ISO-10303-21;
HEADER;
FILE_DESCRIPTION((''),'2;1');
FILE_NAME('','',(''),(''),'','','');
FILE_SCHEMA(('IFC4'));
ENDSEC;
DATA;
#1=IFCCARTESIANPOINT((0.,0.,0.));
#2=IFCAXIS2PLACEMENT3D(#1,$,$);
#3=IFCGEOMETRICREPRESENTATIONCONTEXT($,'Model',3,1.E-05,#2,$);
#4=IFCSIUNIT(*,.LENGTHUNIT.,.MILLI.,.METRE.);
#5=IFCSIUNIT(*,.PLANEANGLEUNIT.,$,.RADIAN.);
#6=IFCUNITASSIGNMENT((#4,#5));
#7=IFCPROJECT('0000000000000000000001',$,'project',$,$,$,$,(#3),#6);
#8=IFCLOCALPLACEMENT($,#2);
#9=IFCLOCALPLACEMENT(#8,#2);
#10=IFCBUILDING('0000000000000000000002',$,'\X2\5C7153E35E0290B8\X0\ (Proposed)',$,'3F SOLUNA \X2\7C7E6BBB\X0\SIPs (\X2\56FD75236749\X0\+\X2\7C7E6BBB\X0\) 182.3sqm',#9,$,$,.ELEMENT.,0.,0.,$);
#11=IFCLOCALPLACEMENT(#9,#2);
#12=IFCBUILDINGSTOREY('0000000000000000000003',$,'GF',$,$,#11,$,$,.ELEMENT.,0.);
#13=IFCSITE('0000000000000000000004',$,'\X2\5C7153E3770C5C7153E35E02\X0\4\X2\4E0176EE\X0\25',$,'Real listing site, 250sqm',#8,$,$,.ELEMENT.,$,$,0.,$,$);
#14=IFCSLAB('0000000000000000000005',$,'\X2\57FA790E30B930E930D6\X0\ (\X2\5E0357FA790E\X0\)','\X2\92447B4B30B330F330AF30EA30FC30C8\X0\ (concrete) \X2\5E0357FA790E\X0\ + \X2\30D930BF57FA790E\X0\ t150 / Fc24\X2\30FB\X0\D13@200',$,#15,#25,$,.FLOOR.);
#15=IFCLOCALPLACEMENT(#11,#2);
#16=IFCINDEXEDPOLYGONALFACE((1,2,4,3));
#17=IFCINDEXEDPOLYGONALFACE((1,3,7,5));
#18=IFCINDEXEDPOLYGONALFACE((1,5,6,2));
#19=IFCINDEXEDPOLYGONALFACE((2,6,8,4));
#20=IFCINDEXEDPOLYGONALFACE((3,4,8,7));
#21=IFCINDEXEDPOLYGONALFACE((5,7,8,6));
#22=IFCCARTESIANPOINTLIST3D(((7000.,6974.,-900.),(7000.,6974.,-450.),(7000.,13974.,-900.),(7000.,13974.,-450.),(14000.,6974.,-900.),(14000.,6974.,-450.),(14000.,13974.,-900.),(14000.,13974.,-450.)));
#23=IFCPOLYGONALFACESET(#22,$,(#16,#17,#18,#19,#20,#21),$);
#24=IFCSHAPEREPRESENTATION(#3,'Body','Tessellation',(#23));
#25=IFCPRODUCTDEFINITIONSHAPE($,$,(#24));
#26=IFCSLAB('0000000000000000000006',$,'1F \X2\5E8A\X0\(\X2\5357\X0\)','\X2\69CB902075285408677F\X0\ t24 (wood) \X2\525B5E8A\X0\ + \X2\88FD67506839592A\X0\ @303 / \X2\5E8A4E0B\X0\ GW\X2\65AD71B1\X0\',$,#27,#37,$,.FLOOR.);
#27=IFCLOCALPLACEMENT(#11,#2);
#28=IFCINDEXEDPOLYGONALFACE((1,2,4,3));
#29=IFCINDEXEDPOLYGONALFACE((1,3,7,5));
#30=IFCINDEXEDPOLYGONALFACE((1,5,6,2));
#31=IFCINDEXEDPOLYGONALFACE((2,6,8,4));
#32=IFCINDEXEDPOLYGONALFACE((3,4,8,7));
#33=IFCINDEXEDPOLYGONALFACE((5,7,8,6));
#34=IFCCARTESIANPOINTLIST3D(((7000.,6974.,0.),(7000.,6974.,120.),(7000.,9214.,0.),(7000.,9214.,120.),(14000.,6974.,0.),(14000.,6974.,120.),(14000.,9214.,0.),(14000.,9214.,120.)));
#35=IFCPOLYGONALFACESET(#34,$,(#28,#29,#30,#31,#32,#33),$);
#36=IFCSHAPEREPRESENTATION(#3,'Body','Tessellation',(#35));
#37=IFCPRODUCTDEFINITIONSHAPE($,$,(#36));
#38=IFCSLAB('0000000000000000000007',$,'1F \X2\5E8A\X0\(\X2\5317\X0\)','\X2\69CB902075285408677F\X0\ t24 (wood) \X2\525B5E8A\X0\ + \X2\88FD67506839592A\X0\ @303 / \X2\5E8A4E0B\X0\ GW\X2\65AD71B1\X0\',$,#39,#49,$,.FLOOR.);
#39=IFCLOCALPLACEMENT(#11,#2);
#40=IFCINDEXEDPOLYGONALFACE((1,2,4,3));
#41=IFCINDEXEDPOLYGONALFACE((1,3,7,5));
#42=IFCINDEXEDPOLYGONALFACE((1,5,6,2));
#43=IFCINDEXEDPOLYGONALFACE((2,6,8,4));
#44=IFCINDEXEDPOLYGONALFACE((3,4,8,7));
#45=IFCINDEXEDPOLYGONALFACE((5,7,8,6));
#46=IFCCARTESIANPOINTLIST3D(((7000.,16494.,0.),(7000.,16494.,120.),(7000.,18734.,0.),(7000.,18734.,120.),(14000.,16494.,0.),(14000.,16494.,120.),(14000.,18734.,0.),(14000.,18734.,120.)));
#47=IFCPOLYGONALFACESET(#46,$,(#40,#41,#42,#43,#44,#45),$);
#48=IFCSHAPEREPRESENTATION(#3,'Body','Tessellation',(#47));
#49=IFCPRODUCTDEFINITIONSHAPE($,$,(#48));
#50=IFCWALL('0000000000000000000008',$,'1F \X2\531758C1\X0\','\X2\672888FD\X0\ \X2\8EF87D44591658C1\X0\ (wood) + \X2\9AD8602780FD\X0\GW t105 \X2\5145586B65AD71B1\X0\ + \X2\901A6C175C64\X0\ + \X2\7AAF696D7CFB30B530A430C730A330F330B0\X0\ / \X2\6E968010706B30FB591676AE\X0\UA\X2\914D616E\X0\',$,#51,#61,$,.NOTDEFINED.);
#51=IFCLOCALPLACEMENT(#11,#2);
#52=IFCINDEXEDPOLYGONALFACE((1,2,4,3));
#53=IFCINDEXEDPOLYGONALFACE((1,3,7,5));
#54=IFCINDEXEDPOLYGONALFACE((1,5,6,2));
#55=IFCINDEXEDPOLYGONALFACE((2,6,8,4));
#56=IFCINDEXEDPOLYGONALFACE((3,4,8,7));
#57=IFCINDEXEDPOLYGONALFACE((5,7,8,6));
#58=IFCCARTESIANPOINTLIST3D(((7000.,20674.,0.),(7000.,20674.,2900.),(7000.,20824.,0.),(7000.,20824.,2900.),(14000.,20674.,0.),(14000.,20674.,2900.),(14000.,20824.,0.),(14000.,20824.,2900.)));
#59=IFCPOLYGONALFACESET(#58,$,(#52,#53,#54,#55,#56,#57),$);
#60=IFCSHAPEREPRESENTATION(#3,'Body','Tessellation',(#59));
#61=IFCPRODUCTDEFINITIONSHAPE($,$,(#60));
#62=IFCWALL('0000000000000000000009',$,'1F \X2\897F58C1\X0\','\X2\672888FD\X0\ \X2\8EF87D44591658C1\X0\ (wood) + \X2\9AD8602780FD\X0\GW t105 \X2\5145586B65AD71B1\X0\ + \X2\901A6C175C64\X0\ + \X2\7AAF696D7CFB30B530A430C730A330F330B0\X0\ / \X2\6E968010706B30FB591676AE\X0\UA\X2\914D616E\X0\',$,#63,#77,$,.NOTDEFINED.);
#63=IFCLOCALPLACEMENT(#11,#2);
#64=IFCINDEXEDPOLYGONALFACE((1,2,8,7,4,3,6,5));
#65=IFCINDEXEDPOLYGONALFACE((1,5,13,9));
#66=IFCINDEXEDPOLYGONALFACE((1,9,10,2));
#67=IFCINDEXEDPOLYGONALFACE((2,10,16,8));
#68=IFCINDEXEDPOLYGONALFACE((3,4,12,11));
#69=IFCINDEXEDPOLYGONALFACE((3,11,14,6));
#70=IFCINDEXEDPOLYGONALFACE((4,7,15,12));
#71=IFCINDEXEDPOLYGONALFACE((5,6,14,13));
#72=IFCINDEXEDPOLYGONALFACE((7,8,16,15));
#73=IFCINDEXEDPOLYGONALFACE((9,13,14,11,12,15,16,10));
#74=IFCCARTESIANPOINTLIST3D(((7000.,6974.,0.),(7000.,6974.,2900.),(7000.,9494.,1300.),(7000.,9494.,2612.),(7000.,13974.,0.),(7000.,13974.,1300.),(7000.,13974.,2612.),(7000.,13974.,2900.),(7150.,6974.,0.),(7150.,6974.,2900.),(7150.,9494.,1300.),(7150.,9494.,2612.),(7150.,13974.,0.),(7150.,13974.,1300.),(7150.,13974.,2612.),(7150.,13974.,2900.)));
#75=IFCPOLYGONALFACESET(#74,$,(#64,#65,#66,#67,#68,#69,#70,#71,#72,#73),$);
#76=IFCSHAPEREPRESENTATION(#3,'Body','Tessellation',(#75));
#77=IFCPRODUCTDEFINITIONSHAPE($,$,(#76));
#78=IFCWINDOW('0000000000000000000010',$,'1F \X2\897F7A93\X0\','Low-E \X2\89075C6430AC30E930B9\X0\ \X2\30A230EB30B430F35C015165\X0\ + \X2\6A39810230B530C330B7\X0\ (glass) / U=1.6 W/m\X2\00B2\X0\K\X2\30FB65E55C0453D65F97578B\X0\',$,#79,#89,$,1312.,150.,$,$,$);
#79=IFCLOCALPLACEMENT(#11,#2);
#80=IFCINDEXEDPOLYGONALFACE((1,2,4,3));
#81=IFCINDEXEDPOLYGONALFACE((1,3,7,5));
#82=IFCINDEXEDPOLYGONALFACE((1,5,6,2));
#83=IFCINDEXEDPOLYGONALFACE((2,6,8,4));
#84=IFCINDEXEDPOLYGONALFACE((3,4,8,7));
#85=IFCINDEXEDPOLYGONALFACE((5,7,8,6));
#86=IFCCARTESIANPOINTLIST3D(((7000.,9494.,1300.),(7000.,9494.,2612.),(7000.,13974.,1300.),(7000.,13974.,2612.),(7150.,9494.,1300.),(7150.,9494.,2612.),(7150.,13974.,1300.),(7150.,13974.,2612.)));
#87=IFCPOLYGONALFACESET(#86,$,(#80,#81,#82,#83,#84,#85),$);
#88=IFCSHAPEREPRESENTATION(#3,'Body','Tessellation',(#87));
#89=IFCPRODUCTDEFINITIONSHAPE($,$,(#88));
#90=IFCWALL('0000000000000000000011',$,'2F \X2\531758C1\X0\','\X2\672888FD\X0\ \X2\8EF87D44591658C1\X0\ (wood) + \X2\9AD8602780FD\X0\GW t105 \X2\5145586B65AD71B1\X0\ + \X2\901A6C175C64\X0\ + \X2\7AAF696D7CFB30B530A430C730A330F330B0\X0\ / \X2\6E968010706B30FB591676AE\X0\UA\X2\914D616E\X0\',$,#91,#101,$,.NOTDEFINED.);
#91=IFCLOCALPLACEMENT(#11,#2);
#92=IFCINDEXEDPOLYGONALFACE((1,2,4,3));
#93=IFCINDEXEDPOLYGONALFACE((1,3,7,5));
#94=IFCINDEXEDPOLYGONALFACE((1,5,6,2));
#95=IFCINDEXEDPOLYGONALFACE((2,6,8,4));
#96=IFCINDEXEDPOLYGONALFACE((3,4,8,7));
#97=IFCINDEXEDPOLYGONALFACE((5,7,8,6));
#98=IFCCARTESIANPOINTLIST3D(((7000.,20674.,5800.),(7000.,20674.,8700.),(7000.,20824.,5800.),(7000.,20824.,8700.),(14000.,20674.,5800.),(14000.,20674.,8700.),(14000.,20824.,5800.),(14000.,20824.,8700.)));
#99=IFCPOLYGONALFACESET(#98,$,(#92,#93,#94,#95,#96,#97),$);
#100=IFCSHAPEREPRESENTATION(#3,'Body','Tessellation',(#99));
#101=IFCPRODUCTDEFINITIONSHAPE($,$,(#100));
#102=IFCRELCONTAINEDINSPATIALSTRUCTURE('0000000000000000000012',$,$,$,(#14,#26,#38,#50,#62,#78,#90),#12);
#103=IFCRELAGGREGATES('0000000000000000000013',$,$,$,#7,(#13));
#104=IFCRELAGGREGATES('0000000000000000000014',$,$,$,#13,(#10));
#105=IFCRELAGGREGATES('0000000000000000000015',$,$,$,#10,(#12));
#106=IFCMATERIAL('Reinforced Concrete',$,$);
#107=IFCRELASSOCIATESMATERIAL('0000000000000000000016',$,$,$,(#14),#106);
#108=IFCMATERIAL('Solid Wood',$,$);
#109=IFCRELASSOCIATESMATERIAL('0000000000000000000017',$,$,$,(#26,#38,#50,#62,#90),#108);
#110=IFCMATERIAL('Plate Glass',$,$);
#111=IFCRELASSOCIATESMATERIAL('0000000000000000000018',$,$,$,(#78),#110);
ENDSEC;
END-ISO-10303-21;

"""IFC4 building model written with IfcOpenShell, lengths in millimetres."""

from ifc_helpers import new_model, si_unit, frame, frame_2d, origin, place, context, project, spatial, rectangle, extrude, material, element, fill, save


model = new_model("IFC4")

# Units and contexts
model_context = context("Model", 3, precision=1e-05, world=origin())
ifc_project = project(units=[si_unit("LENGTHUNIT", "METRE", prefix="MILLI"), si_unit("PLANEANGLEUNIT", "RADIAN")], contexts=[model_context])

# Site, building, storey
site_placement = place(None, origin())
site = spatial("IfcSite", under=ifc_project, at=site_placement, Name="山口県山口市4丁目25", ObjectType="Real listing site, 250sqm", CompositionType="ELEMENT", RefElevation=0.0)
building_placement = place(site_placement, origin())
building = spatial("IfcBuilding", under=site, at=building_placement, Name="山口市邸 (Proposed)", ObjectType="3F SOLUNA 籾殻SIPs (国産杉+籾殻) 182.3sqm", CompositionType="ELEMENT", ElevationOfRefHeight=0.0, ElevationOfTerrain=0.0)
storey_placement = place(building_placement, origin())
storey = spatial("IfcBuildingStorey", under=building, at=storey_placement, Name="GF", CompositionType="ELEMENT", Elevation=0.0)

# Slabs
ifc_material_1 = material(Name="Reinforced Concrete")
slab_1_placement = place(storey_placement, frame((3500.0, 3487.0, -450.0)))
element("IfcSlab", 1, at=slab_1_placement, inside=storey, material=ifc_material_1, Name="基礎スラブ (布基礎)", Description="鉄筋コンクリート (concrete) 布基礎 + ベタ基礎 t150 / Fc24・D13@200", PredefinedType="FLOOR", context=model_context, shape_type="SweptSolid", body=[
    extrude(rectangle(XDim=7000.0, YDim=7000.0, at=frame_2d((3500.0, 3500.0))), frame((3500.0, 3487.0, -450.0)), (0.0, 0.0, 1.0), 450.0),
])
ifc_material_2 = material(Name="Solid Wood")
slab_2_placement = place(storey_placement, frame((3500.0, 3487.0, 0.0)))
element("IfcSlab", 2, at=slab_2_placement, inside=storey, material=ifc_material_2, Name="1F 床(南)", Description="構造用合板 t24 (wood) 剛床 + 製材根太 @303 / 床下 GW断熱", PredefinedType="FLOOR", context=model_context, shape_type="SweptSolid", body=[
    extrude(rectangle(XDim=7000.0, YDim=2240.0, at=frame_2d((3500.0, 1120.0))), frame((3500.0, 3487.0, 0.0)), (0.0, 0.0, 1.0), 120.0),
])
slab_3_placement = place(storey_placement, frame((3500.0, 8247.0, 0.0)))
element("IfcSlab", 3, at=slab_3_placement, inside=storey, material=ifc_material_2, Name="1F 床(北)", Description="構造用合板 t24 (wood) 剛床 + 製材根太 @303 / 床下 GW断熱", PredefinedType="FLOOR", context=model_context, shape_type="SweptSolid", body=[
    extrude(rectangle(XDim=7000.0, YDim=2240.0, at=frame_2d((3500.0, 1120.0))), frame((3500.0, 8247.0, 0.0)), (0.0, 0.0, 1.0), 120.0),
])

# Shared definitions
ifc_material_3 = material(Name="Plate Glass")

# Wall
wall_1_placement = place(storey_placement, frame((3500.0, 10337.0, 0.0)))
element("IfcWall", 4, at=wall_1_placement, inside=storey, material=ifc_material_2, Name="1F 北壁", Description="木製 軸組外壁 (wood) + 高性能GW t105 充填断熱 + 通気層 + 窯業系サイディング / 準耐火・外皮UA配慮", PredefinedType="NOTDEFINED", context=model_context, shape_type="SweptSolid", body=[
    extrude(rectangle(XDim=7000.0, YDim=150.0, at=frame_2d((3500.0, 75.0))), frame((3500.0, 10337.0, 0.0)), (0.0, 0.0, 1.0), 2900.0),
])

# Wall, opening, window
wall_2_placement = place(storey_placement, frame((3500.0, 3487.0, 0.0)))
wall_2 = element("IfcWall", 5, at=wall_2_placement, inside=storey, material=ifc_material_2, Name="1F 西壁", Description="木製 軸組外壁 (wood) + 高性能GW t105 充填断熱 + 通気層 + 窯業系サイディング / 準耐火・外皮UA配慮", PredefinedType="NOTDEFINED", context=model_context, shape_type="SweptSolid", body=[
    extrude(rectangle(XDim=150.0, YDim=7000.0, at=frame_2d((75.0, 3500.0))), frame((3500.0, 3487.0, 0.0)), (0.0, 0.0, 1.0), 2900.0),
])
opening_1_placement = place(storey_placement, frame((3500.0, 4747.0, 650.0)))
opening_1 = element("IfcOpeningElement", 6, at=opening_1_placement, cuts=wall_2, PredefinedType="NOTDEFINED", context=model_context, shape_type="SweptSolid", body=[
    extrude(rectangle(XDim=150.0, YDim=4480.0, at=frame_2d((75.0, 2240.0))), frame((3500.0, 4747.0, 650.0)), (0.0, 0.0, 1.0), 1312.0),
])
window_1_placement = place(storey_placement, frame((3500.0, 4747.0, 650.0)))
window_1 = element("IfcWindow", 7, at=window_1_placement, inside=storey, material=ifc_material_3, Name="1F 西窓", Description="Low-E 複層ガラス アルゴン封入 + 樹脂サッシ (glass) / U=1.6 W/m²K・日射取得型", OverallHeight=1312.0, OverallWidth=150.0, context=model_context, shape_type="SweptSolid", body=[
    extrude(rectangle(XDim=150.0, YDim=4480.0, at=frame_2d((75.0, 2240.0))), frame((3500.0, 4747.0, 650.0)), (0.0, 0.0, 1.0), 1312.0),
])
fill(opening_1, window_1)

# Wall
wall_3_placement = place(storey_placement, frame((3500.0, 10337.0, 2900.0)))
element("IfcWall", 8, at=wall_3_placement, inside=storey, material=ifc_material_2, Name="2F 北壁", Description="木製 軸組外壁 (wood) + 高性能GW t105 充填断熱 + 通気層 + 窯業系サイディング / 準耐火・外皮UA配慮", PredefinedType="NOTDEFINED", context=model_context, shape_type="SweptSolid", body=[
    extrude(rectangle(XDim=7000.0, YDim=150.0, at=frame_2d((3500.0, 75.0))), frame((3500.0, 10337.0, 2900.0)), (0.0, 0.0, 1.0), 2900.0),
])

save(model, "model.ifc")
